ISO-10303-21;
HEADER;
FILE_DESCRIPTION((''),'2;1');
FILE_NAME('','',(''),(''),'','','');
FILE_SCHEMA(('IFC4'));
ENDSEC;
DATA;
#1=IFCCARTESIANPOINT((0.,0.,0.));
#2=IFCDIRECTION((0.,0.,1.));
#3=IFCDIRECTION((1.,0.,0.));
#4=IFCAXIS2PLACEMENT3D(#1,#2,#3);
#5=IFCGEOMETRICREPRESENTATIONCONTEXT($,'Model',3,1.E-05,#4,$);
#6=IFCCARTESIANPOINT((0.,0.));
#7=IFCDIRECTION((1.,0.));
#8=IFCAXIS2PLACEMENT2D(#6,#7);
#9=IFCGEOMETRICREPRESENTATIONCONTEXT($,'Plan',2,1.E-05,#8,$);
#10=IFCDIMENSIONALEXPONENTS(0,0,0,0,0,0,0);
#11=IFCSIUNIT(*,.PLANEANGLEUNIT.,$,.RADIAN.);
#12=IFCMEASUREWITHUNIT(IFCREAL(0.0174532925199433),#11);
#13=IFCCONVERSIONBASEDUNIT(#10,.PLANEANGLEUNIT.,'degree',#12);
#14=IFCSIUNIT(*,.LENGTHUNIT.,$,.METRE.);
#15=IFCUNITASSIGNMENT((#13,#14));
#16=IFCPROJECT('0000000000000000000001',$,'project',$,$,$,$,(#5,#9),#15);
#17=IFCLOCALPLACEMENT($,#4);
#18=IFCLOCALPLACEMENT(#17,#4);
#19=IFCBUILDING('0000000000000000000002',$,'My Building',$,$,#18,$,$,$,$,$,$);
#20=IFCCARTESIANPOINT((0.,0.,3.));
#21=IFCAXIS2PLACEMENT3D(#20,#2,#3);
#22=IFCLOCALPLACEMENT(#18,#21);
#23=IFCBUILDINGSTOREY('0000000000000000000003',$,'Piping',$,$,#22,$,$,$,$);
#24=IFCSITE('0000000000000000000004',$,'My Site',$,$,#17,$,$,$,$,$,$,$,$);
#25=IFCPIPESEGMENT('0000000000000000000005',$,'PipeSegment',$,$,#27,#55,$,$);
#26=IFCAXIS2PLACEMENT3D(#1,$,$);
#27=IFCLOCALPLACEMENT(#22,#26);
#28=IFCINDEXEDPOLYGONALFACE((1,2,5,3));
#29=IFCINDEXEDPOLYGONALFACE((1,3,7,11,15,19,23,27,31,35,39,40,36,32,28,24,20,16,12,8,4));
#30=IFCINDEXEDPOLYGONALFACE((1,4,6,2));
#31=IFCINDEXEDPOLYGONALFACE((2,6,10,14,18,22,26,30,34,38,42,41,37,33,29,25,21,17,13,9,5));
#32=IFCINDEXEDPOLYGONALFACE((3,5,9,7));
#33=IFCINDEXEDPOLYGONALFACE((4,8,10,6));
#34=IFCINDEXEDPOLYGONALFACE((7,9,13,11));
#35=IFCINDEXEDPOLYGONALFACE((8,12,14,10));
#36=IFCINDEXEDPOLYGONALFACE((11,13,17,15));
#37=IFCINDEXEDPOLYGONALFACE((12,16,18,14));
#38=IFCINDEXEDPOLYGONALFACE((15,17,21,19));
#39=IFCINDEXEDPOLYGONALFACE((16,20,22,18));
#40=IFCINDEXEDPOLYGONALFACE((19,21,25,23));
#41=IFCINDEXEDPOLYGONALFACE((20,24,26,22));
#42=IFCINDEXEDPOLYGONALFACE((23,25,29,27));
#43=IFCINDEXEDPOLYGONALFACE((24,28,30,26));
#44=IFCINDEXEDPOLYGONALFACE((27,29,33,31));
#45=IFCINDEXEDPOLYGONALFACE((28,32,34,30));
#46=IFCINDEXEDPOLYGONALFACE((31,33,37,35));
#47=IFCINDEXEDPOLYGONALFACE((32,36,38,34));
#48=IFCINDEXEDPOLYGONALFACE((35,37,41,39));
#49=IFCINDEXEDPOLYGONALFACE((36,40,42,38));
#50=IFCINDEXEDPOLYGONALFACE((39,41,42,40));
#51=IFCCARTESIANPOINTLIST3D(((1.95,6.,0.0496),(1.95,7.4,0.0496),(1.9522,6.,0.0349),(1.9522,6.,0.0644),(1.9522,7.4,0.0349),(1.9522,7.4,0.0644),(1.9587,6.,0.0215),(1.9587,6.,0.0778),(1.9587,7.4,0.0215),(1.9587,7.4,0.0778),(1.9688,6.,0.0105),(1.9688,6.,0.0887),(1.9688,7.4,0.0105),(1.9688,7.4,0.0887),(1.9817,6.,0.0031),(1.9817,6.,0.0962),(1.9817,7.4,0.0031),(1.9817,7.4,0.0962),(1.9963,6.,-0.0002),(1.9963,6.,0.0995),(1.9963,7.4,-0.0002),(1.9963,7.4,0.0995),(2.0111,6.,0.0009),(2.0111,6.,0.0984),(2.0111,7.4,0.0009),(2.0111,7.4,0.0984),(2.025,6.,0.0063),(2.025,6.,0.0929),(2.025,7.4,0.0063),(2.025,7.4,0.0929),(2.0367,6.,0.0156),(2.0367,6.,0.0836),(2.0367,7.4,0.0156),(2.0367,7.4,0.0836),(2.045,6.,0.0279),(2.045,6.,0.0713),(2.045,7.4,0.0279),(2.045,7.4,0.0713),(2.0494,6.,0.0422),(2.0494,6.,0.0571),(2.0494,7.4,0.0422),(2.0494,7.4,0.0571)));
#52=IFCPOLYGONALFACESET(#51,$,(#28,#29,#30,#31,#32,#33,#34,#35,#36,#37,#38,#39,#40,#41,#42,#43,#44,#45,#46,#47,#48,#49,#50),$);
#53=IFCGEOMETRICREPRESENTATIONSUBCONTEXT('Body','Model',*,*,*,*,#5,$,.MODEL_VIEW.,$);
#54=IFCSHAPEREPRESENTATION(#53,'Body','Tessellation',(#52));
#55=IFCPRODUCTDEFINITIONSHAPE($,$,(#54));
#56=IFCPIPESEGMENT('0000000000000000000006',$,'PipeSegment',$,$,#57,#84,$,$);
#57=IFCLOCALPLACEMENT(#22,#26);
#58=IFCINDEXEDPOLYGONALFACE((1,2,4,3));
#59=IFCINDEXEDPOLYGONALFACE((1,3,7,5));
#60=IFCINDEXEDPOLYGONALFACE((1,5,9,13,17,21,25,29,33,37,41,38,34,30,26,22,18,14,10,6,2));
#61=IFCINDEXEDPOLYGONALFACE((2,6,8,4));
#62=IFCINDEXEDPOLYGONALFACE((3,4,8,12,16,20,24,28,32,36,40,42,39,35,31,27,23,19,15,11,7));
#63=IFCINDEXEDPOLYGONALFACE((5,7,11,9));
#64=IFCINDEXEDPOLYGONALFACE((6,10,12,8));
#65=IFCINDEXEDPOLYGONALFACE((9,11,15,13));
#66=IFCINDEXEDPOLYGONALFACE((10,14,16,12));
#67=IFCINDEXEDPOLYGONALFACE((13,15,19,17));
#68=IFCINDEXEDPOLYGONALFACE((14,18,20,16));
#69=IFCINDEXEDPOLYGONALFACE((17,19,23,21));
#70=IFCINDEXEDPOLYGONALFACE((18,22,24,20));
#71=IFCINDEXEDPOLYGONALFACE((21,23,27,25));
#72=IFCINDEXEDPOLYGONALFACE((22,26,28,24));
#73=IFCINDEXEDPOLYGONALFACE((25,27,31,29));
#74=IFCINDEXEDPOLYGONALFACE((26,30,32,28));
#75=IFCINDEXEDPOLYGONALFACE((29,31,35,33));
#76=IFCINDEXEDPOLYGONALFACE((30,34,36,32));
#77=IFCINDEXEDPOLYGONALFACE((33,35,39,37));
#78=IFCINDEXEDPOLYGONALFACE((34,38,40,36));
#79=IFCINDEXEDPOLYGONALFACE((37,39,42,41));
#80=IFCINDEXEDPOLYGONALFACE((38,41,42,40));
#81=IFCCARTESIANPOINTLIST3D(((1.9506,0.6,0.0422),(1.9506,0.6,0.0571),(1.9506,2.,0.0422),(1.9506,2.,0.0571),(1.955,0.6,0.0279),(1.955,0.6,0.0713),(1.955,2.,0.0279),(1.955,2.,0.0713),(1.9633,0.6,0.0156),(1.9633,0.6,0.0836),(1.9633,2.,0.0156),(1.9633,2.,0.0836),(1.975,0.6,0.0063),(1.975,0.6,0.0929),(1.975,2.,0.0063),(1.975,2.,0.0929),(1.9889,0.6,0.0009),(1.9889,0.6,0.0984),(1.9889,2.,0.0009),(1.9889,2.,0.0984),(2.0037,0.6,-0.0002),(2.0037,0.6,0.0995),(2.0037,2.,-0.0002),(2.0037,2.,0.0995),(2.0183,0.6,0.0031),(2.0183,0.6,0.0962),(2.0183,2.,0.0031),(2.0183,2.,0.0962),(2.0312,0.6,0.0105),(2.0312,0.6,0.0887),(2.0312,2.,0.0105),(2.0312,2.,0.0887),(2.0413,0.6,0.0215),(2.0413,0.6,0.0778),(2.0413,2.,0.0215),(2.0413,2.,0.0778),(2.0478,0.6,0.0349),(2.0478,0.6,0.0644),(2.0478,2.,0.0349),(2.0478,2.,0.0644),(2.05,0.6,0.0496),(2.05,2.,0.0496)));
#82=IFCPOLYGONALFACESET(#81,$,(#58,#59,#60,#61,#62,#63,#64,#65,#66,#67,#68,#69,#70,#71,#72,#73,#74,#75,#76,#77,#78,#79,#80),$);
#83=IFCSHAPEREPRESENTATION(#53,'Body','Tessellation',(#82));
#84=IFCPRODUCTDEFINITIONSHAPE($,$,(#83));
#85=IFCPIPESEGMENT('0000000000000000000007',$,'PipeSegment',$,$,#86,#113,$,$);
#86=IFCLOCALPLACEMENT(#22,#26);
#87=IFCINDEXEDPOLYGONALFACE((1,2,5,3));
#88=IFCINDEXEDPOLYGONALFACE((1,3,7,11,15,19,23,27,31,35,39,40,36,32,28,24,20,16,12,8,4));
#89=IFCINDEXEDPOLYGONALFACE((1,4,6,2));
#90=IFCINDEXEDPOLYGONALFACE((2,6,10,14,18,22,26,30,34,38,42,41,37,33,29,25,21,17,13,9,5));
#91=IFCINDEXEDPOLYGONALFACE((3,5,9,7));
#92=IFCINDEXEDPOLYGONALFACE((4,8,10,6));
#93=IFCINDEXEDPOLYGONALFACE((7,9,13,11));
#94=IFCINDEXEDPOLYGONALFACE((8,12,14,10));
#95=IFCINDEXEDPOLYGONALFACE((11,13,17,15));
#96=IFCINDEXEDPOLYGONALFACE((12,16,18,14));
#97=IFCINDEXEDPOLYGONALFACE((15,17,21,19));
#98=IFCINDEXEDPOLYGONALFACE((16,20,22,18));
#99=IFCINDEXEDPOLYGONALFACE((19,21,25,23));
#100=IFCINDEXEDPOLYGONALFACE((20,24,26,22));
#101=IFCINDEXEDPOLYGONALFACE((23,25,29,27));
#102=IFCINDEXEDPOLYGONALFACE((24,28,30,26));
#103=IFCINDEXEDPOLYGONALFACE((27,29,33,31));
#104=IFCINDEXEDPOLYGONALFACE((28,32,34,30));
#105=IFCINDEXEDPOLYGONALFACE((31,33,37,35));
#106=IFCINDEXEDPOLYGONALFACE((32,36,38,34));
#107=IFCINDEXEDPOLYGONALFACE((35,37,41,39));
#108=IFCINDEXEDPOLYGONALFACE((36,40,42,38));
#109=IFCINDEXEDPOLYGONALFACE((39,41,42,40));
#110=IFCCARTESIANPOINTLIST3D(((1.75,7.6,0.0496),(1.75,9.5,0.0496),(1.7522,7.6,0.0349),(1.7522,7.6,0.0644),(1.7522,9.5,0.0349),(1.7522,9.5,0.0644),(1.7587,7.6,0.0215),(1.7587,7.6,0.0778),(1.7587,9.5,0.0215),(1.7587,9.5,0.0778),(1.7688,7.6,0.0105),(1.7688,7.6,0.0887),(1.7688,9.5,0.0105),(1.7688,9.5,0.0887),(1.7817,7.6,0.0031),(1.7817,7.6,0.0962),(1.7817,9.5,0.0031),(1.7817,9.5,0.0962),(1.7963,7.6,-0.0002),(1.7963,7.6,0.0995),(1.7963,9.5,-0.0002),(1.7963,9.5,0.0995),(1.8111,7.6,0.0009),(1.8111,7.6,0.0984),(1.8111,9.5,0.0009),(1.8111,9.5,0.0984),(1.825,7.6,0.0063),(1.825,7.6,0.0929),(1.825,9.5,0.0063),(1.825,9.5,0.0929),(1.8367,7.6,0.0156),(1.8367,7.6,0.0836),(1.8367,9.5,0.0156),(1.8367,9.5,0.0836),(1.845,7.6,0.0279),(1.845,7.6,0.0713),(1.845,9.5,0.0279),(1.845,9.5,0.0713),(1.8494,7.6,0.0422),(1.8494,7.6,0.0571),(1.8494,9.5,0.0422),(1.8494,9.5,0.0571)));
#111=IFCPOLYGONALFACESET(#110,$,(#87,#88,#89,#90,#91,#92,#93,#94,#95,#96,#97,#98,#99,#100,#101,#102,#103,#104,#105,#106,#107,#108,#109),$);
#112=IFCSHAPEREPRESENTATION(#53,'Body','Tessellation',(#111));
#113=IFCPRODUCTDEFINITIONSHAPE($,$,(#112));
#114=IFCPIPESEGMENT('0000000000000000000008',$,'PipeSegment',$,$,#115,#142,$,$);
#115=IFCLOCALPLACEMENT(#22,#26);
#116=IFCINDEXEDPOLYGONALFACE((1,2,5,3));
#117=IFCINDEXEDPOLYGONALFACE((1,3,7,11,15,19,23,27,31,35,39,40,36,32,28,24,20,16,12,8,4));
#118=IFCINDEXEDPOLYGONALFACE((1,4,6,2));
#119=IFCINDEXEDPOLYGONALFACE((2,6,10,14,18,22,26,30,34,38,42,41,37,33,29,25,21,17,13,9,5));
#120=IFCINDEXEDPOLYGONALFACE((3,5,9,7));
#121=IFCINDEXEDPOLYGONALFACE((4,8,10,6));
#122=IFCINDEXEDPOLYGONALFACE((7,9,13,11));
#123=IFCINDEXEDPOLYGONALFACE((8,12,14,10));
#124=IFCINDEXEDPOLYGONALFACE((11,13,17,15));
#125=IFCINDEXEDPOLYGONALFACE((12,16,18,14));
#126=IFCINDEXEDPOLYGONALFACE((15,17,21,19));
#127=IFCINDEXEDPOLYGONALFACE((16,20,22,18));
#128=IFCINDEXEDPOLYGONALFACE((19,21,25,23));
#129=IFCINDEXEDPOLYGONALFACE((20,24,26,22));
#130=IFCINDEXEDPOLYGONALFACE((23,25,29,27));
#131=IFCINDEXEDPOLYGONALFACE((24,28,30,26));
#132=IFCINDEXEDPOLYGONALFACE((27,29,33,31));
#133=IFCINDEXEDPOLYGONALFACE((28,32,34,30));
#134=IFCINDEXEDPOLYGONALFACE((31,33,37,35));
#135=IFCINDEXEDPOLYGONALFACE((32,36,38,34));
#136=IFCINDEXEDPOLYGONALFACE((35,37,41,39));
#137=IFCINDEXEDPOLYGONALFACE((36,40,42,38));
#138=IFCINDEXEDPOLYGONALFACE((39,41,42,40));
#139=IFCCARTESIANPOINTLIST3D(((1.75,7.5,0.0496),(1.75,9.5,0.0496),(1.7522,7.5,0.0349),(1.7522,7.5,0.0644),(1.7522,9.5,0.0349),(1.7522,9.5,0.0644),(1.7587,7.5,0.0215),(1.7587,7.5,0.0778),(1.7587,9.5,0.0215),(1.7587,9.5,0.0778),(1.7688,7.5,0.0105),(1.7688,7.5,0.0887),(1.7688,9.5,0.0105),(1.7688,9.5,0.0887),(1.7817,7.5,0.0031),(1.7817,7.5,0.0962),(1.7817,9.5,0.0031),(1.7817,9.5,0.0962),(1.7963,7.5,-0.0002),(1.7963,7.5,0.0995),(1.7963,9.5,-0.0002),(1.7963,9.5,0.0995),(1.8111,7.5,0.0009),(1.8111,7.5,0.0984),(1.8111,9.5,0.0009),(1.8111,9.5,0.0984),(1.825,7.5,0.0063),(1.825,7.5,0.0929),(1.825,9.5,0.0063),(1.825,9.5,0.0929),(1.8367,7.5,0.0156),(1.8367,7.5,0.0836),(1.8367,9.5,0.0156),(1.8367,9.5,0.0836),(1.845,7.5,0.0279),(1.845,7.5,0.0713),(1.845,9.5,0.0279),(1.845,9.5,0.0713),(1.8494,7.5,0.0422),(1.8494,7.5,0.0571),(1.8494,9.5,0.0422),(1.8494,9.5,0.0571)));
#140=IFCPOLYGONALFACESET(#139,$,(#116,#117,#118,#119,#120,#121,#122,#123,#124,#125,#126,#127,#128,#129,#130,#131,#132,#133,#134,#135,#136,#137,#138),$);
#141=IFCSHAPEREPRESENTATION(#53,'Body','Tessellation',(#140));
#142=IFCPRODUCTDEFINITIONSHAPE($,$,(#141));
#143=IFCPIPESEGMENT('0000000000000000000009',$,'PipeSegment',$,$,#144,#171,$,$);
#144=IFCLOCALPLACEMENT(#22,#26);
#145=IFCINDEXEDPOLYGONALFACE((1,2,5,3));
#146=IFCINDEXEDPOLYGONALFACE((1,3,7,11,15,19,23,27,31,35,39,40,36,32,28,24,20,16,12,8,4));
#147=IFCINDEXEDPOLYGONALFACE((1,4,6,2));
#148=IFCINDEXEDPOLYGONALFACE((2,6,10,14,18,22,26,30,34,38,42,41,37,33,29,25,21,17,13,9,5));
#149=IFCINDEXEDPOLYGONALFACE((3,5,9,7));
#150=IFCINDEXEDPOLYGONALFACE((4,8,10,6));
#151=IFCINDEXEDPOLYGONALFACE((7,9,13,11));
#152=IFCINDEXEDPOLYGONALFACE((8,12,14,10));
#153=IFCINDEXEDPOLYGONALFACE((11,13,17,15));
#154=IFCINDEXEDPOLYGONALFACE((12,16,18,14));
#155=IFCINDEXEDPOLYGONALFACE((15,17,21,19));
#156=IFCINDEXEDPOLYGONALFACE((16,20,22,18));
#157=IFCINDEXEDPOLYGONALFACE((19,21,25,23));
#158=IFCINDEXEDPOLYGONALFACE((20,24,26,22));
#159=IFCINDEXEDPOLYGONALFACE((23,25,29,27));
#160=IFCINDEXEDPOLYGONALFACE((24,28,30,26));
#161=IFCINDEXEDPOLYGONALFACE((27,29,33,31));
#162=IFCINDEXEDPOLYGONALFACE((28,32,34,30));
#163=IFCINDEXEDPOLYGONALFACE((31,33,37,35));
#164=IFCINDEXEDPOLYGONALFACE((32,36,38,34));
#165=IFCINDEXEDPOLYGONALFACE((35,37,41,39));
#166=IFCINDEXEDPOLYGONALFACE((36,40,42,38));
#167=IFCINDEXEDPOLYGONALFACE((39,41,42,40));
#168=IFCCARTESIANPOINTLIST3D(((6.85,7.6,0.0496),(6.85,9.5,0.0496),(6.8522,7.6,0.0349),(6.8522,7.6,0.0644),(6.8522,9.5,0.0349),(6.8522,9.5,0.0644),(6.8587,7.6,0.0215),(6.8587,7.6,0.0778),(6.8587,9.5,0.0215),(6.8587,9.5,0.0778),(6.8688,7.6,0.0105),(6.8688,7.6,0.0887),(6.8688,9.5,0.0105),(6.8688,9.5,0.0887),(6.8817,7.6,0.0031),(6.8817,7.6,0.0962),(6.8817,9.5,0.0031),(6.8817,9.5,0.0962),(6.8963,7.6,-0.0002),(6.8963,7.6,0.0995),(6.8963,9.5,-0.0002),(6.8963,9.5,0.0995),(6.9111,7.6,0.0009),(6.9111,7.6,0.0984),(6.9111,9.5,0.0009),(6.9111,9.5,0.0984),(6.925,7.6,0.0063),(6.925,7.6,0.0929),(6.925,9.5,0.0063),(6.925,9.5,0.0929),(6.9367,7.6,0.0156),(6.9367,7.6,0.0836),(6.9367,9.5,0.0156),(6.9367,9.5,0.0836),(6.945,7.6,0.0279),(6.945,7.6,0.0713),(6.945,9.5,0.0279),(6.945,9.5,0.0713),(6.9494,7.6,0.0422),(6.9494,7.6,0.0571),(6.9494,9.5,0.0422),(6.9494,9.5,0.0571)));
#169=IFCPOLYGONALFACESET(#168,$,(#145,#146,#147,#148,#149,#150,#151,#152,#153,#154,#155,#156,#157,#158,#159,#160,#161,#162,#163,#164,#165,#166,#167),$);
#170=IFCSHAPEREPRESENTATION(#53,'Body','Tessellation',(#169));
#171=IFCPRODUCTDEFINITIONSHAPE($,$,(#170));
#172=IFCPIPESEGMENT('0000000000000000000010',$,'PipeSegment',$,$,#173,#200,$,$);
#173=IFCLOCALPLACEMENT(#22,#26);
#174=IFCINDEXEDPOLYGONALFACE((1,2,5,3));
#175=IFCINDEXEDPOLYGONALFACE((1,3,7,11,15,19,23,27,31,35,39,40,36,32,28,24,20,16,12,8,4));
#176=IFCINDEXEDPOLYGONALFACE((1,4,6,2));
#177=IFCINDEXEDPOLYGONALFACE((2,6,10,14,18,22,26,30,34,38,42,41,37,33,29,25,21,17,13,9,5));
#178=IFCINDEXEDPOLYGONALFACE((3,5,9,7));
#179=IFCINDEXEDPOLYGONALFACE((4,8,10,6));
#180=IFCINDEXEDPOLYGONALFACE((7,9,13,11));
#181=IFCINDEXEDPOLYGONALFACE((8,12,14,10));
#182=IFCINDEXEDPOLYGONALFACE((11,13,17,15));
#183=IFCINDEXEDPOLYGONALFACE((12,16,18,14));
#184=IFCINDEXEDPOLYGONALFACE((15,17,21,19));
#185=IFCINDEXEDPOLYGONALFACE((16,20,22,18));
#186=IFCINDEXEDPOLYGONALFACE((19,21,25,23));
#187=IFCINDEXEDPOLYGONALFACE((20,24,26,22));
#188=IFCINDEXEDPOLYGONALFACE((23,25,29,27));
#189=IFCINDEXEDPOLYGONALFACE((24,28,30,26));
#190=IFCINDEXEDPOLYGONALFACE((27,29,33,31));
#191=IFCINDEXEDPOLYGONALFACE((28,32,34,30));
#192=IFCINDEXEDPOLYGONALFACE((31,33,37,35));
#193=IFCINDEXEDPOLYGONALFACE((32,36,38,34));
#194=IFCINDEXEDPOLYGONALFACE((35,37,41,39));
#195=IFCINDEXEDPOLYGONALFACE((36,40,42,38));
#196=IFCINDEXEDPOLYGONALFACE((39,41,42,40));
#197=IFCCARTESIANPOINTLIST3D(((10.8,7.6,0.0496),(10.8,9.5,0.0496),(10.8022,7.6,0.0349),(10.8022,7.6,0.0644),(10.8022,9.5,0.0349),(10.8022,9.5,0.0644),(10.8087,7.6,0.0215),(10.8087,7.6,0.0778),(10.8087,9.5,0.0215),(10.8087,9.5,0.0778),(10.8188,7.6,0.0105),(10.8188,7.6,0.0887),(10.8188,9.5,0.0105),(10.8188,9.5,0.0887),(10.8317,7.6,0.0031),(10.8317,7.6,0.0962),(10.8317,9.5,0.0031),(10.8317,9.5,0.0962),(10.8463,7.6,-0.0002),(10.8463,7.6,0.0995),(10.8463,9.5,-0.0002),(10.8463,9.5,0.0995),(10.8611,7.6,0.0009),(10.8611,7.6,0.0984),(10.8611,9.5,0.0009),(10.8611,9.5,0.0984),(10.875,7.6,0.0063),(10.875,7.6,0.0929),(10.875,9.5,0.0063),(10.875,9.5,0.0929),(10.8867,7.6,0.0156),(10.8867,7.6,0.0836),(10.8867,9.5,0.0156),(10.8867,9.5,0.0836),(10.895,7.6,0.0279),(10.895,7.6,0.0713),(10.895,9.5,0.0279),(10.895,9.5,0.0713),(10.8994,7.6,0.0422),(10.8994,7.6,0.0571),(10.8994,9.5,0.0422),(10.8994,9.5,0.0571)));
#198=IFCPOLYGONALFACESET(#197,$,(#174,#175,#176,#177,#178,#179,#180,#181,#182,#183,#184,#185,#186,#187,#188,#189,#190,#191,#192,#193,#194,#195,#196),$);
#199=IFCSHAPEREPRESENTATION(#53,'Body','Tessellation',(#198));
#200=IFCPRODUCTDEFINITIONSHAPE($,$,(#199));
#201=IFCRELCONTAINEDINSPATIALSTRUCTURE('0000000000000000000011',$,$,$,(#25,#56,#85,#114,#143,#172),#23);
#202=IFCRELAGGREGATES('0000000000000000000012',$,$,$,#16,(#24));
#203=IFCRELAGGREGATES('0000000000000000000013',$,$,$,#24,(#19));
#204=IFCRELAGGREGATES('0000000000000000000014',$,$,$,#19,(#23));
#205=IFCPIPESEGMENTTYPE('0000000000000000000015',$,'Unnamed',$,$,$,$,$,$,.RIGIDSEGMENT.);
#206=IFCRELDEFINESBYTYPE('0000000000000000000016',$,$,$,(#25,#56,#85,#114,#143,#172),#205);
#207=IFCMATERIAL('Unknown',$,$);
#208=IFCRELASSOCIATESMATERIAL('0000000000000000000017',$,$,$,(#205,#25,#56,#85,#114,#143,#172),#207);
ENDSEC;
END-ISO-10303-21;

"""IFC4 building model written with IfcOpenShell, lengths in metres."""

from ifc_helpers import new_model, entity, si_unit, converted_unit, frame, origin_with_axes, origin_2d_with_axis, place, context, subcontext, project, spatial, circle, extrude, material, material_profile, profile_set, profile_usage, type_object, element, save


model = new_model("IFC4")

# Units and contexts
model_context = context("Model", 3, precision=1e-05, world=origin_with_axes())
plan_context = context("Plan", 2, precision=1e-05, world=origin_2d_with_axis())
body_context = subcontext(model_context, "Body", "Model", "MODEL_VIEW")
ifc_project = project(units=[converted_unit("PLANEANGLEUNIT", "degree", entity("IfcReal", 0.0174532925199433), si_unit("PLANEANGLEUNIT", "RADIAN"), dimensions=[0, 0, 0, 0, 0, 0, 0]), si_unit("LENGTHUNIT", "METRE")], contexts=[model_context, plan_context])

# Site, building, storey
site_placement = place(None, origin_with_axes())
site = spatial("IfcSite", under=ifc_project, at=site_placement, Name="My Site")
building_placement = place(site_placement, origin_with_axes())
building = spatial("IfcBuilding", under=site, at=building_placement, Name="My Building")
storey_placement = place(building_placement, frame((0.0, 0.0, 3.0), z_axis=(0.0, 0.0, 1.0), x_axis=(1.0, 0.0, 0.0)))
storey = spatial("IfcBuildingStorey", under=building, at=storey_placement, Name="Piping")

# Shared definitions
ifc_material = material(Name="Unknown")

# Pipe segments
ifc_material_profile_1 = material_profile(ifc_material, circle(Radius=0.05))
ifc_profile_set_1 = profile_set([ifc_material_profile_1])
pipe_segment_type = type_object("IfcPipeSegmentType", Name="Unnamed", PredefinedType="RIGIDSEGMENT", material=ifc_profile_set_1)
ifc_profile_usage_1 = profile_usage(ifc_profile_set_1, cardinal=5)
pipe_segment_1_placement = place(storey_placement, frame((2.0, 6.0, 0.0496), z_axis=(0.0, 1.0, 0.0), x_axis=(-1.0, 0.0, 0.0)))
element("IfcPipeSegment", 1, at=pipe_segment_1_placement, inside=storey, type_object=pipe_segment_type, material=ifc_profile_usage_1, Name="PipeSegment", context=body_context, shape_type="SweptSolid", body=[
    extrude(circle(Radius=0.05), origin_with_axes(), (0.0, 0.0, 1.0), 1.4),
])
ifc_profile_usage_2 = profile_usage(ifc_profile_set_1, cardinal=5)
pipe_segment_2_placement = place(storey_placement, frame((2.0, 2.0, 0.0496), z_axis=(0.0, -1.0, 0.0), x_axis=(1.0, 0.0, 0.0)))
element("IfcPipeSegment", 2, at=pipe_segment_2_placement, inside=storey, type_object=pipe_segment_type, material=ifc_profile_usage_2, Name="PipeSegment", context=body_context, shape_type="SweptSolid", body=[
    extrude(circle(Radius=0.05), origin_with_axes(), (0.0, 0.0, 1.0), 1.4),
])
ifc_profile_usage_3 = profile_usage(ifc_profile_set_1, cardinal=5)
pipe_segment_3_placement = place(storey_placement, frame((1.8, 7.6, 0.0496), z_axis=(0.0, 1.0, 0.0), x_axis=(-1.0, 0.0, 0.0)))
element("IfcPipeSegment", 3, at=pipe_segment_3_placement, inside=storey, type_object=pipe_segment_type, material=ifc_profile_usage_3, Name="PipeSegment", context=body_context, shape_type="SweptSolid", body=[
    extrude(circle(Radius=0.05), origin_with_axes(), (0.0, 0.0, 1.0), 1.9),
])
ifc_profile_usage_4 = profile_usage(ifc_profile_set_1, cardinal=5)
pipe_segment_4_placement = place(storey_placement, frame((1.8, 7.5, 0.0496), z_axis=(0.0, 1.0, 0.0), x_axis=(-1.0, 0.0, 0.0)))
element("IfcPipeSegment", 4, at=pipe_segment_4_placement, inside=storey, type_object=pipe_segment_type, material=ifc_profile_usage_4, Name="PipeSegment", context=body_context, shape_type="SweptSolid", body=[
    extrude(circle(Radius=0.05), origin_with_axes(), (0.0, 0.0, 1.0), 2.0),
])
ifc_profile_usage_5 = profile_usage(ifc_profile_set_1, cardinal=5)
pipe_segment_5_placement = place(storey_placement, frame((6.9, 7.6, 0.0496), z_axis=(0.0, 1.0, 0.0), x_axis=(-1.0, 0.0, 0.0)))
element("IfcPipeSegment", 5, at=pipe_segment_5_placement, inside=storey, type_object=pipe_segment_type, material=ifc_profile_usage_5, Name="PipeSegment", context=body_context, shape_type="SweptSolid", body=[
    extrude(circle(Radius=0.05), origin_with_axes(), (0.0, 0.0, 1.0), 1.9),
])
ifc_profile_usage_6 = profile_usage(ifc_profile_set_1, cardinal=5)
pipe_segment_6_placement = place(storey_placement, frame((10.85, 7.6, 0.0496), z_axis=(0.0, 1.0, 0.0), x_axis=(-1.0, 0.0, 0.0)))
element("IfcPipeSegment", 6, at=pipe_segment_6_placement, inside=storey, type_object=pipe_segment_type, material=ifc_profile_usage_6, Name="PipeSegment", context=body_context, shape_type="SweptSolid", body=[
    extrude(circle(Radius=0.05), origin_with_axes(), (0.0, 0.0, 1.0), 1.9),
])

save(model, "model.ifc")
